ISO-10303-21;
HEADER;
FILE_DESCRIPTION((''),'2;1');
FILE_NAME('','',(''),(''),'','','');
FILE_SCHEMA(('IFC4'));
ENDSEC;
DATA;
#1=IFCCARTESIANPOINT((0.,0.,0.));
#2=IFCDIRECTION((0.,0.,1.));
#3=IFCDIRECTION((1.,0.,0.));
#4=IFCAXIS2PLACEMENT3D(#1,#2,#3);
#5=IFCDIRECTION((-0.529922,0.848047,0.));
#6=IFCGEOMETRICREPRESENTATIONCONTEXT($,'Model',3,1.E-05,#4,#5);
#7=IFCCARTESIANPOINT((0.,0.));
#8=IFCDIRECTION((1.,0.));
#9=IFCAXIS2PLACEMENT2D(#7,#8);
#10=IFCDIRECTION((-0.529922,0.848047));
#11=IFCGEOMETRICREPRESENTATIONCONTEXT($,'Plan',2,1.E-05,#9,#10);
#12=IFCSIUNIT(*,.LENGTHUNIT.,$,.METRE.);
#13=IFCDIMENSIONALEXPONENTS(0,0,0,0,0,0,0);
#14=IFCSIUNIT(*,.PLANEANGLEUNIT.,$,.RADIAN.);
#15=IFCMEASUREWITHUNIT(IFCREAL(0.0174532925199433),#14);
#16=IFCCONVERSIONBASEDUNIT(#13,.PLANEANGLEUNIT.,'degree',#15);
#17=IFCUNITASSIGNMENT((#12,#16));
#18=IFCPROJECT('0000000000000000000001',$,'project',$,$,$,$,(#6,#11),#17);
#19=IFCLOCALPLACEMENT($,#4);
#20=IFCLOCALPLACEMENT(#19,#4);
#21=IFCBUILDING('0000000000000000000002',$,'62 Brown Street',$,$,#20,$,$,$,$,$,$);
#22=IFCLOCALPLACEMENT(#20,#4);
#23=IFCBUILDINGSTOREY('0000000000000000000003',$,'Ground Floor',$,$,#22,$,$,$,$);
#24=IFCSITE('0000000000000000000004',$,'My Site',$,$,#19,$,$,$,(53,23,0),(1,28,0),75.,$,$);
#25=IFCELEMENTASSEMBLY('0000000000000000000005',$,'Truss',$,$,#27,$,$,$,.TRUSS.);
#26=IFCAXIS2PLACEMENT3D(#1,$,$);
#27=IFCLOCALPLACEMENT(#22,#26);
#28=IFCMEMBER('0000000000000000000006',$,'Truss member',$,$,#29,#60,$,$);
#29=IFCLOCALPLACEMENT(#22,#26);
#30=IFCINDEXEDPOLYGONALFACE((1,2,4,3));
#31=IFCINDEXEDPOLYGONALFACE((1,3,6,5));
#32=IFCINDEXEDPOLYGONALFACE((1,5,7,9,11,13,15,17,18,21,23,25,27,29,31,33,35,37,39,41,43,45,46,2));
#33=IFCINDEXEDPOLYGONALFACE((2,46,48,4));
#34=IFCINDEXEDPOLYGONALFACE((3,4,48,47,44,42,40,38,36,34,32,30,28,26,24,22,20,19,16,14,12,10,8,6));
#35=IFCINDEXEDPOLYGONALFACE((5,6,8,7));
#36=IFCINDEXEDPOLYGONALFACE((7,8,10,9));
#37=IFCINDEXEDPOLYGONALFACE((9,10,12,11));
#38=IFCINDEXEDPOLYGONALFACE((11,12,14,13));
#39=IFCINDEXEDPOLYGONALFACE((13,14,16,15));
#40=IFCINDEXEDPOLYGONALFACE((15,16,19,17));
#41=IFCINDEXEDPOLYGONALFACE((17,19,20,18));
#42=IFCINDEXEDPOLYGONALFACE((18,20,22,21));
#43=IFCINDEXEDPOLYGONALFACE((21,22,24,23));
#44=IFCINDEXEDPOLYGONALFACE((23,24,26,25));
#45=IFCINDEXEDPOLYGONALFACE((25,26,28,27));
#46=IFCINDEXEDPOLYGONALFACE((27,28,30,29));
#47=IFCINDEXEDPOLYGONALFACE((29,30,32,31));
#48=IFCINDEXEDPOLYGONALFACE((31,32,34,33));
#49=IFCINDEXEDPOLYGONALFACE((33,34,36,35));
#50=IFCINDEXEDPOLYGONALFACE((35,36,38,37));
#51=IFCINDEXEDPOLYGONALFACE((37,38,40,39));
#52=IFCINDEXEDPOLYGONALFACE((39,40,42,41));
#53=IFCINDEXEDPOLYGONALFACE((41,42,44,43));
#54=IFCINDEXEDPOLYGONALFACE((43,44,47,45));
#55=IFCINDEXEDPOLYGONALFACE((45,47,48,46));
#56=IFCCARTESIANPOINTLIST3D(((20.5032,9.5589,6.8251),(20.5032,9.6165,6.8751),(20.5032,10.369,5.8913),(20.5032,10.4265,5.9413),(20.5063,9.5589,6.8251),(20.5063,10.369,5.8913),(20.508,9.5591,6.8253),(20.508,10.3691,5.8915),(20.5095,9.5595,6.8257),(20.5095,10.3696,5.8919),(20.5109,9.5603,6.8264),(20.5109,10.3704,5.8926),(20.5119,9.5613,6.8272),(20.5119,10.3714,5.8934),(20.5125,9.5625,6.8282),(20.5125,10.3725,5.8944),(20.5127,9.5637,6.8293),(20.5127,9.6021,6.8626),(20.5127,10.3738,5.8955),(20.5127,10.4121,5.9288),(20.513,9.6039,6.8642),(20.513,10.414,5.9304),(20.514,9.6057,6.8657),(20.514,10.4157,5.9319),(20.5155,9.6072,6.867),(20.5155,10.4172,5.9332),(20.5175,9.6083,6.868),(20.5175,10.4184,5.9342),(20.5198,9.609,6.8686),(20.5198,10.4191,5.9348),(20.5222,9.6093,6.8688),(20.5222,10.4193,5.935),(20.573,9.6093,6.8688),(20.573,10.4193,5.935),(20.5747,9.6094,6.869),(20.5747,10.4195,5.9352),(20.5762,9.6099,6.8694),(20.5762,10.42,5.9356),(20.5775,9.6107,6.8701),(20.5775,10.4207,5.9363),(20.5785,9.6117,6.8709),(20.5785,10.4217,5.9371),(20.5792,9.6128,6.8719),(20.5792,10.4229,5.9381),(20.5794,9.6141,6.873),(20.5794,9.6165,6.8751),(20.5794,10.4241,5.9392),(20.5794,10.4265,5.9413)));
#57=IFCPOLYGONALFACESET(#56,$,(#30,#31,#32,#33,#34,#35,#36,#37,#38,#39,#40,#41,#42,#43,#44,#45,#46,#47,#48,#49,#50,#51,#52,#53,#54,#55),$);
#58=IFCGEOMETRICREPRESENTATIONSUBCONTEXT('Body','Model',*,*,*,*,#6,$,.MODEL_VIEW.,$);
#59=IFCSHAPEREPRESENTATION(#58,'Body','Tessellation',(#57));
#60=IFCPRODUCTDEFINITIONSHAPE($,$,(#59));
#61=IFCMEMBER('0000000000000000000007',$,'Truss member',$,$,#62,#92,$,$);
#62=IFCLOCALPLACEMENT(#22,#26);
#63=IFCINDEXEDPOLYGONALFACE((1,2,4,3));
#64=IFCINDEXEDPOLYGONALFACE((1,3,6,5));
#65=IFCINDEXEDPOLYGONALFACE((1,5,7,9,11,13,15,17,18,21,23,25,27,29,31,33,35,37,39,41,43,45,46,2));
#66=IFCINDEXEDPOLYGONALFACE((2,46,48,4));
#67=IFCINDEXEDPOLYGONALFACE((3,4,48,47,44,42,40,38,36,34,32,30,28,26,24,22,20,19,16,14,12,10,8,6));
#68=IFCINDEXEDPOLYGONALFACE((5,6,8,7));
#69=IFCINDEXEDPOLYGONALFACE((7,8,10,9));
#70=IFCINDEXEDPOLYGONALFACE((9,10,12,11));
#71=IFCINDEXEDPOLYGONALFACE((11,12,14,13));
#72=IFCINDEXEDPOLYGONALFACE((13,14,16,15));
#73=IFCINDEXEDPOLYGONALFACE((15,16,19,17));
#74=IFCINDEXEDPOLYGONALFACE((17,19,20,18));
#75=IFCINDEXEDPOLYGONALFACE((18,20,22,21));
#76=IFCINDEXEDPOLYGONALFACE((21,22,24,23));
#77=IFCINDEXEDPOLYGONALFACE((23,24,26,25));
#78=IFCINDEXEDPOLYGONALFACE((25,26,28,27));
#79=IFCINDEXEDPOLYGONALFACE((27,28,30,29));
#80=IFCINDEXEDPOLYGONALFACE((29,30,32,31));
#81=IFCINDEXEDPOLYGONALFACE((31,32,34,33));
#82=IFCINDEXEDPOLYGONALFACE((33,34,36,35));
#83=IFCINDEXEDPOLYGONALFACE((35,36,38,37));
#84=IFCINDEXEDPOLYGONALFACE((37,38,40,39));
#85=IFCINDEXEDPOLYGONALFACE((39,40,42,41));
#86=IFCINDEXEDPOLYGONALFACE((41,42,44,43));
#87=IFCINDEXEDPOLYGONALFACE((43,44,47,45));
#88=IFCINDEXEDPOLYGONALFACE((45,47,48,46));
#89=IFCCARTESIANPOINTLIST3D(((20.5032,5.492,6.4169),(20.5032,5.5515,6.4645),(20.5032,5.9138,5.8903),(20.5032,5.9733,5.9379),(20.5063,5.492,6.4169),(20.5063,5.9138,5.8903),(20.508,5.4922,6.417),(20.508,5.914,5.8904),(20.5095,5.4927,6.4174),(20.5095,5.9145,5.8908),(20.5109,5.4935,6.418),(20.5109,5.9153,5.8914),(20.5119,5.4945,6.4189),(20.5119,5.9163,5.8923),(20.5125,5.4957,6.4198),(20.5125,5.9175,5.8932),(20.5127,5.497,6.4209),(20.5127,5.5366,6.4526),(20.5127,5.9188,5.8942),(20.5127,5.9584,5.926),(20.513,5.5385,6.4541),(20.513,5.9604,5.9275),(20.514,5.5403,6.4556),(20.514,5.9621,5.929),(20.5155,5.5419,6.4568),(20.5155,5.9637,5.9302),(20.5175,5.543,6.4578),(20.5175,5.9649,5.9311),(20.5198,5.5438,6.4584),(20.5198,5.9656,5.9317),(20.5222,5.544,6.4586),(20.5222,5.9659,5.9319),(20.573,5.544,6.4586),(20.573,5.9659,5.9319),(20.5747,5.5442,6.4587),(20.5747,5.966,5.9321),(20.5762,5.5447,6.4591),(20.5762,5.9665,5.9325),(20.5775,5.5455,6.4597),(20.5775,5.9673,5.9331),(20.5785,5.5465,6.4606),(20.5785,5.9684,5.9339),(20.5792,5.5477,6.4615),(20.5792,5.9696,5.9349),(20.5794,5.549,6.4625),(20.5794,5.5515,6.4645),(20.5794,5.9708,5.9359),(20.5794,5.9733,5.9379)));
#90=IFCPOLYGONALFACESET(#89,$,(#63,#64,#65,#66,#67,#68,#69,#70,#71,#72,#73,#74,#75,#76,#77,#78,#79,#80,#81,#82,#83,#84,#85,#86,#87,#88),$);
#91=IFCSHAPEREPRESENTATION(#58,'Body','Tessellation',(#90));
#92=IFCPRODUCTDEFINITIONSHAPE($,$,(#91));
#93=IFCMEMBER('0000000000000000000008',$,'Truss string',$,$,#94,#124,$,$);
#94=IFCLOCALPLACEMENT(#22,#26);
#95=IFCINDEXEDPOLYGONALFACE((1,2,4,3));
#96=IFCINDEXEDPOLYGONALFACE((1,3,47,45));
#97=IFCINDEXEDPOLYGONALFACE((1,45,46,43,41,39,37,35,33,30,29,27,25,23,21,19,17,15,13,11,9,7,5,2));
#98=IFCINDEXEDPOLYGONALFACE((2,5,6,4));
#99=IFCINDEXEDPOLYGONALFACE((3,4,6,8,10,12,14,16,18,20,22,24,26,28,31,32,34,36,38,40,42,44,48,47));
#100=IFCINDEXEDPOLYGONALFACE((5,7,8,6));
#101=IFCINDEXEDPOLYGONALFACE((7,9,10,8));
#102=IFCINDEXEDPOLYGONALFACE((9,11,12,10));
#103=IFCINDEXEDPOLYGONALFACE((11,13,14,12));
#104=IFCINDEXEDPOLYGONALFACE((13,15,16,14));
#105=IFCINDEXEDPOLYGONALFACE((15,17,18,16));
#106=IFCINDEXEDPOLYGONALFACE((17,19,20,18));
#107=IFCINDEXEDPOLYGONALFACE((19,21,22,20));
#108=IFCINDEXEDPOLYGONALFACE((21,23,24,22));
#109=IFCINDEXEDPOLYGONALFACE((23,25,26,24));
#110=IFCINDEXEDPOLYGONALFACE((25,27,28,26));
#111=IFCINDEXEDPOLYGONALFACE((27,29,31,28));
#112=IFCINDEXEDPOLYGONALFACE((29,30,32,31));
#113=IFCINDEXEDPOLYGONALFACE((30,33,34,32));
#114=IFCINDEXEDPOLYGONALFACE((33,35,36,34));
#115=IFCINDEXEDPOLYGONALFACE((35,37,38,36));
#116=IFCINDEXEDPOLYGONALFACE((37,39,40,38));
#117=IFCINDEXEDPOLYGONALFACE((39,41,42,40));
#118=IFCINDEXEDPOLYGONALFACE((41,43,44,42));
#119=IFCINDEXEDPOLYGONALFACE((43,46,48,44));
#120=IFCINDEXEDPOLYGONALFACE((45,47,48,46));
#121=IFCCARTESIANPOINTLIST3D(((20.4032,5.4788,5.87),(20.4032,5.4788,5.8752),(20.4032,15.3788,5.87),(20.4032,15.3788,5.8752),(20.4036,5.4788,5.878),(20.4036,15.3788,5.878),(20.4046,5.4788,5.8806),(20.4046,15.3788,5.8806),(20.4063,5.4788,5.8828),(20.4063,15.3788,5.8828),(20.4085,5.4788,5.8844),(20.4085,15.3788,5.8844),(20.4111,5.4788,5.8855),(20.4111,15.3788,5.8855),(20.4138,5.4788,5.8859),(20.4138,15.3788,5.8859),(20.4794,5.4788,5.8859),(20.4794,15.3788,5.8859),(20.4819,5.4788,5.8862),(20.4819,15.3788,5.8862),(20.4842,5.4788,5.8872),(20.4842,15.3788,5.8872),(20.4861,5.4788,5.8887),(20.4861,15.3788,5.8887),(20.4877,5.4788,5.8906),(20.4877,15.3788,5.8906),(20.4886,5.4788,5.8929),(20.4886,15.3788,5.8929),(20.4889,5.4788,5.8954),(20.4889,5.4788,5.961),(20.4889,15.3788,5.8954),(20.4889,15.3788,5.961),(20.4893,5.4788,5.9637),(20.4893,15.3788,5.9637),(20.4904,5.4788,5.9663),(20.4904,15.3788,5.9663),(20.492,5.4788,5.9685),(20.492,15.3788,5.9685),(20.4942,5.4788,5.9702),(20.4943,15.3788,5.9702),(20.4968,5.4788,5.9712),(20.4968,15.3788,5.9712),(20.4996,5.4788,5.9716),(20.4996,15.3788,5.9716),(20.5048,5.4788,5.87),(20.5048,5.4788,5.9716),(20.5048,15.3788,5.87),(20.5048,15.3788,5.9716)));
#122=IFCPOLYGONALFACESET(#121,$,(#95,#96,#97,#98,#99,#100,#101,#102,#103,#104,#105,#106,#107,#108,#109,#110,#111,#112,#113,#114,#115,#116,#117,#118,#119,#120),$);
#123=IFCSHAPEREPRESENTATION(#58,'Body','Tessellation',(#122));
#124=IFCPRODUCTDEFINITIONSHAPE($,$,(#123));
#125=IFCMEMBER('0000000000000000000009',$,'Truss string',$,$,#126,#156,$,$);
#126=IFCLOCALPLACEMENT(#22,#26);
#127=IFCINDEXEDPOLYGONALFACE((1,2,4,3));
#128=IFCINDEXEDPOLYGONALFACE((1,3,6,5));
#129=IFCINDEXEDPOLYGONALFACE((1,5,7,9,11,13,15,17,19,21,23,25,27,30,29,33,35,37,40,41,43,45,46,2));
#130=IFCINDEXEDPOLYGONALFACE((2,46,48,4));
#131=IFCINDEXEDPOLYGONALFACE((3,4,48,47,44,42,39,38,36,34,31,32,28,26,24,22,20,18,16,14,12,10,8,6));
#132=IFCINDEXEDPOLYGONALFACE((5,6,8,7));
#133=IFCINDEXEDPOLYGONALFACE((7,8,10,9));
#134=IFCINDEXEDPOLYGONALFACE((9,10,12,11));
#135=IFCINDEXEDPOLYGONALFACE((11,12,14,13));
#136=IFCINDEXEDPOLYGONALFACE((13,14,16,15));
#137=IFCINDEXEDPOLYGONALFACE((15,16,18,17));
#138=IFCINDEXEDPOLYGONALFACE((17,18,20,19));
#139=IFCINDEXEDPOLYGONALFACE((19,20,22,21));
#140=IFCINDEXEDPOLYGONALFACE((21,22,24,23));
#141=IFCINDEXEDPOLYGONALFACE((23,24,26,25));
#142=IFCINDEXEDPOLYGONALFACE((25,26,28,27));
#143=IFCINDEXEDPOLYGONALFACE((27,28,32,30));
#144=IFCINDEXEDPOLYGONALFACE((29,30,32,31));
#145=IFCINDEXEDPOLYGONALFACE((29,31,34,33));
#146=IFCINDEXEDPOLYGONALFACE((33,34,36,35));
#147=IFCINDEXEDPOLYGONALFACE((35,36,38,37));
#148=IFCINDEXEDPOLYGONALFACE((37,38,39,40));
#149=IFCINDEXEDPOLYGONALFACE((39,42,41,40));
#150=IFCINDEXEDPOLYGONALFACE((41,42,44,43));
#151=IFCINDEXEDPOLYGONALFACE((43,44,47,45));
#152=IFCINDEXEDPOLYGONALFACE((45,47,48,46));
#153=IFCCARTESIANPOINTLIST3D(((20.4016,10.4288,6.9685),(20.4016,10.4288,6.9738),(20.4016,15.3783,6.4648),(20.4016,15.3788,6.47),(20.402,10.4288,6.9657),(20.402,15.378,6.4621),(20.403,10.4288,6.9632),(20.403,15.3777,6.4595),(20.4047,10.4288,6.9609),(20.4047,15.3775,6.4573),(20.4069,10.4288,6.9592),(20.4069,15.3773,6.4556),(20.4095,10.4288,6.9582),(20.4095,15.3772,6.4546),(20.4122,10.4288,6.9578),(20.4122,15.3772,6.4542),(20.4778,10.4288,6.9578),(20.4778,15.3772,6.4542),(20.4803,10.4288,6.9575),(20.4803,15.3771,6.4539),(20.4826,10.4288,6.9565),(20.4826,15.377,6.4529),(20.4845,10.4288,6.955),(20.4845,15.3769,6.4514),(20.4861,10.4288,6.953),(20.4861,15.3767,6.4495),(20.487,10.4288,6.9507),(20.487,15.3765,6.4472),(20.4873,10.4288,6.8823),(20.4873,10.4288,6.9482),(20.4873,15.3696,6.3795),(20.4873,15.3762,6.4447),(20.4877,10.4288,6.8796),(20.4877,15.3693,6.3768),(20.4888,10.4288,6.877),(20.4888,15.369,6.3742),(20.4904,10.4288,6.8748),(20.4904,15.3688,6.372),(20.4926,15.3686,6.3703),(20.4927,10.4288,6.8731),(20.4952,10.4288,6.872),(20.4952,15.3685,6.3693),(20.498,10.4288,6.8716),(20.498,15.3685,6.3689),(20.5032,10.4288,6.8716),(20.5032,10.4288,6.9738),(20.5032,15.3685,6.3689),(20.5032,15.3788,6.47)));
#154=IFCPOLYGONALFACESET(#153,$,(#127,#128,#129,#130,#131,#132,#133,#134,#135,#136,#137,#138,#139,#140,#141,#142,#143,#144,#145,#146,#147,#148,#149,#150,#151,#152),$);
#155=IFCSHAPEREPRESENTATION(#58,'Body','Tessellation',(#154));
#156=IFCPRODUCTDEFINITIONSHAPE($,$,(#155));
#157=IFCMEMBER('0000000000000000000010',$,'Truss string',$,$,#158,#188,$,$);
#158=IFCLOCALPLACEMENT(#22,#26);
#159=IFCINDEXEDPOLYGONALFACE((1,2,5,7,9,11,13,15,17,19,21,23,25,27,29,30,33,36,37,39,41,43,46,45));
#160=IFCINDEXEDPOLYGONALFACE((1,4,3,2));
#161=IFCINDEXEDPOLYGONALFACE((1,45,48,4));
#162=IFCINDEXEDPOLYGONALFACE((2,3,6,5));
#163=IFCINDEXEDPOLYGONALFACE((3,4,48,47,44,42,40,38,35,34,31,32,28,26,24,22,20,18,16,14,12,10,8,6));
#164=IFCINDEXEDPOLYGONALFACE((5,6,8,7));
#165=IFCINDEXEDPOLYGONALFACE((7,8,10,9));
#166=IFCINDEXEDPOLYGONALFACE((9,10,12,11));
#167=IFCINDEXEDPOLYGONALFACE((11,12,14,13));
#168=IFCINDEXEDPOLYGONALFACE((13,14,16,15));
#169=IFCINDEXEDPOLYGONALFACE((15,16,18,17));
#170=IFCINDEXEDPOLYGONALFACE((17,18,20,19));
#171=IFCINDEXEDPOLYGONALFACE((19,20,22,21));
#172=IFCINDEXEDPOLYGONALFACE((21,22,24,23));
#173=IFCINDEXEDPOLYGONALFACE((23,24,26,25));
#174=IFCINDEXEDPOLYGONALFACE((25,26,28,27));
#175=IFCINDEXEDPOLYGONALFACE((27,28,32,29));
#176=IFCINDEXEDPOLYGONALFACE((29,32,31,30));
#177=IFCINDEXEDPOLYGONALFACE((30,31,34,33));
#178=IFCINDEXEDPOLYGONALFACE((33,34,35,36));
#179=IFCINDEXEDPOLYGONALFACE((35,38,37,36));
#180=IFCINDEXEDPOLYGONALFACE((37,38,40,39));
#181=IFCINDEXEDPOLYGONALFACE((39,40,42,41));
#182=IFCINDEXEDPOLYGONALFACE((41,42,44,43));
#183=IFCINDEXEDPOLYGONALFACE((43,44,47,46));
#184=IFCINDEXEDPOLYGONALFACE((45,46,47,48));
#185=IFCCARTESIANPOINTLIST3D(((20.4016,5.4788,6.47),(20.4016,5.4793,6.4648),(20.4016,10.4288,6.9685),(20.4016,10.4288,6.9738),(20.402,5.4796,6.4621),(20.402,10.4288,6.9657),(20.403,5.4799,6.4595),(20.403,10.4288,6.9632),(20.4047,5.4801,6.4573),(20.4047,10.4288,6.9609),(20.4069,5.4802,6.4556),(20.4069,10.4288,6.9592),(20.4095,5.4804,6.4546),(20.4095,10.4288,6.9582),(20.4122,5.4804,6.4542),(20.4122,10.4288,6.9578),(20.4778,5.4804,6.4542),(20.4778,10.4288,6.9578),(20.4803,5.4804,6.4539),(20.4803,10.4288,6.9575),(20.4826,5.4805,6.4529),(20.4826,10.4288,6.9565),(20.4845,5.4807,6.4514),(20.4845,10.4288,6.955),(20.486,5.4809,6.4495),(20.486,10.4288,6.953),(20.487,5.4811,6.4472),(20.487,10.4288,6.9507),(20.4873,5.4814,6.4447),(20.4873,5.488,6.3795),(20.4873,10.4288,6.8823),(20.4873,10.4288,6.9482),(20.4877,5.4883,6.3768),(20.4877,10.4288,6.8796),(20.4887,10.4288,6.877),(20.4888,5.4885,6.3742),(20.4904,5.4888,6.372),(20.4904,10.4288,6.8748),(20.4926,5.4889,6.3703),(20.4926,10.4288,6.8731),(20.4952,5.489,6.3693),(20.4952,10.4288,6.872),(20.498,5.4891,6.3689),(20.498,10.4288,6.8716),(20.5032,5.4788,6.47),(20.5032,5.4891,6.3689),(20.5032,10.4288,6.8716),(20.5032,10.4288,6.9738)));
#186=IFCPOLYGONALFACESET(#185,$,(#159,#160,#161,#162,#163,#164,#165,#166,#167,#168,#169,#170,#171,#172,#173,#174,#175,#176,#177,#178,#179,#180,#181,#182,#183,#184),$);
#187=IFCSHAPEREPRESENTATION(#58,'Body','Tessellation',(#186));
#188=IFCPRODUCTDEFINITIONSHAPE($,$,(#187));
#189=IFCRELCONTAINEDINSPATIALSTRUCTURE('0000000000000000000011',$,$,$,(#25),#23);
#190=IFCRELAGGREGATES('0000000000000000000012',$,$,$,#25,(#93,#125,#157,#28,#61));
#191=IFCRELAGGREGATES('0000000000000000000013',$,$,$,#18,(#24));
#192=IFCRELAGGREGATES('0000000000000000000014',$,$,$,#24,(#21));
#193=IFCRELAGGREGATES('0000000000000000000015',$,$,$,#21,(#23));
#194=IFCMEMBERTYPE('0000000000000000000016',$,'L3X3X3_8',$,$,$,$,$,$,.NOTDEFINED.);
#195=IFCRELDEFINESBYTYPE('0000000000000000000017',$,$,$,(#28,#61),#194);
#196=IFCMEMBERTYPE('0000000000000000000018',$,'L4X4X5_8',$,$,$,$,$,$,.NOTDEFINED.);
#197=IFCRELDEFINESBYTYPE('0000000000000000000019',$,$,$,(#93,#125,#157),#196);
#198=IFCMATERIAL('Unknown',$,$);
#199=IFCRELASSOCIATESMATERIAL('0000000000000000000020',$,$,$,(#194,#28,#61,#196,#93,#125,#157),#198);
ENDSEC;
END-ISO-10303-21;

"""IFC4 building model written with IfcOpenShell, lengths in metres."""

from ifc_helpers import new_model, entity, si_unit, converted_unit, direction, frame, origin_with_axes, origin_2d_with_axis, place, context, subcontext, project, spatial, l_section, extrude, clip, halfspace, material, material_profile, profile_set, profile_usage, type_object, element, aggregate, save


model = new_model("IFC4")

# Units and contexts
model_context = context("Model", 3, precision=1e-05, world=origin_with_axes(), true_north=direction((-0.529922, 0.848047, 0.0)))
plan_context = context("Plan", 2, precision=1e-05, world=origin_2d_with_axis(), true_north=direction((-0.529922, 0.848047)))
body_context = subcontext(model_context, "Body", "Model", "MODEL_VIEW")
ifc_project = project(units=[si_unit("LENGTHUNIT", "METRE"), converted_unit("PLANEANGLEUNIT", "degree", entity("IfcReal", 0.0174532925199433), si_unit("PLANEANGLEUNIT", "RADIAN"), dimensions=[0, 0, 0, 0, 0, 0, 0])], contexts=[model_context, plan_context])

# Site, building, storey
site_placement = place(None, origin_with_axes())
site = spatial("IfcSite", under=ifc_project, at=site_placement, Name="My Site", RefLatitude=(53, 23, 0), RefLongitude=(1, 28, 0), RefElevation=75.0)
building_placement = place(site_placement, origin_with_axes())
building = spatial("IfcBuilding", under=site, at=building_placement, Name="62 Brown Street")
storey_placement = place(building_placement, origin_with_axes())
storey = spatial("IfcBuildingStorey", under=building, at=storey_placement, Name="Ground Floor")

# Element assembly, members
assembly_placement = place(storey_placement, frame((20.5032, 10.4288, 6.9738), z_axis=(0.0, 0.0, 1.0), x_axis=(1.0, 0.0, 0.0)))
assembly = element("IfcElementAssembly", 1, at=assembly_placement, inside=storey, Name="Truss", PredefinedType="TRUSS")
ifc_material_1 = material(Name="Unknown")
ifc_material_profile_1 = material_profile(ifc_material_1, l_section(Depth=0.0762, Width=0.0762, Thickness=0.0095, FilletRadius=0.0095, EdgeRadius=0.0064))
ifc_profile_set_1 = profile_set([ifc_material_profile_1])
member_type_1 = type_object("IfcMemberType", Name="L3X3X3_8", PredefinedType="NOTDEFINED", material=ifc_profile_set_1)
ifc_profile_usage_1 = profile_usage(ifc_profile_set_1, cardinal=5)
member_1_placement = place(assembly_placement, frame((0.0381, -0.8411, -0.1236), z_axis=(-0.000001, 0.655276, -0.755389), x_axis=(1.0, 0.000001, 0.0)))
member_1 = element("IfcMember", 2, at=member_1_placement, type_object=member_type_1, material=ifc_profile_usage_1, Name="Truss member", context=body_context, shape_type="SweptSolid", body=[
    extrude(l_section(Depth=0.0762, Width=0.0762, Thickness=0.0095, FilletRadius=0.0095, EdgeRadius=0.0064), origin_with_axes(), (0.0, 0.0, 1.0), 1.2362),
])
ifc_profile_usage_2 = profile_usage(ifc_profile_set_1, cardinal=5)
member_2_placement = place(assembly_placement, frame((0.0381, -4.907, -0.5331), z_axis=(-0.000001, 0.625169, -0.780489), x_axis=(1.0, 0.000001, 0.0)))
member_2 = element("IfcMember", 3, at=member_2_placement, type_object=member_type_1, material=ifc_profile_usage_2, Name="Truss member", context=body_context, shape_type="SweptSolid", body=[
    extrude(l_section(Depth=0.0762, Width=0.0762, Thickness=0.0095, FilletRadius=0.0095, EdgeRadius=0.0064), origin_with_axes(), (0.0, 0.0, 1.0), 0.6747),
])

# Members
ifc_material_profile_2 = material_profile(ifc_material_1, l_section(Depth=0.1016, Width=0.1016, Thickness=0.0159, FilletRadius=0.0095, EdgeRadius=0.0106))
ifc_profile_set_2 = profile_set([ifc_material_profile_2])
ifc_profile_usage_3 = profile_usage(ifc_profile_set_2, cardinal=5)
member_type_2 = type_object("IfcMemberType", Name="L4X4X5_8", PredefinedType="NOTDEFINED", material=ifc_profile_set_2)
member_3_placement = place(assembly_placement, frame((-0.0492, -4.95, -1.053), z_axis=(0.0, 1.0, 0.0), x_axis=(-1.0, 0.0, 0.0)))
member_3 = element("IfcMember", 4, at=member_3_placement, type_object=member_type_2, material=ifc_profile_usage_3, Name="Truss string", context=body_context, shape_type="SweptSolid", body=[
    extrude(l_section(Depth=0.1016, Width=0.1016, Thickness=0.0159, FilletRadius=0.0095, EdgeRadius=0.0106), origin_with_axes(), (0.0, 0.0, 1.0), 9.9),
])
ifc_profile_usage_4 = profile_usage(ifc_profile_set_2, cardinal=5)
member_4_placement = place(assembly_placement, frame((-0.0508, 4.9449, -0.5543), z_axis=(0.000001, -0.994861, 0.101247), x_axis=(-1.0, -0.000001, 0.0)))
member_4 = element("IfcMember", 5, at=member_4_placement, type_object=member_type_2, material=ifc_profile_usage_4, Name="Truss string", context=body_context, shape_type="Clipping", body=[
    clip(extrude(l_section(Depth=0.1016, Width=0.1016, Thickness=0.0159, FilletRadius=0.0095, EdgeRadius=0.0106), origin_with_axes(), (0.0, 0.0, 1.0), 5.3242), halfspace(frame((16.4524, -0.0508, 4.9756), z_axis=(0.0, 0.101247, 0.994861), x_axis=(1.0, -0.000001, 0.0)), False)),
])
ifc_profile_usage_5 = profile_usage(ifc_profile_set_2, cardinal=5)
member_5_placement = place(assembly_placement, frame((-0.0508, 0.3519, -0.0152), z_axis=(0.000001, -0.994861, -0.101247), x_axis=(-1.0, -0.000001, 0.0)))
member_5 = element("IfcMember", 6, at=member_5_placement, type_object=member_type_2, material=ifc_profile_usage_5, Name="Truss string", context=body_context, shape_type="Clipping", body=[
    clip(extrude(l_section(Depth=0.1016, Width=0.1016, Thickness=0.0159, FilletRadius=0.0095, EdgeRadius=0.0106), origin_with_axes(), (0.0, 0.0, 1.0), 5.3242), halfspace(frame((16.4524, -0.0508, 0.3486), z_axis=(0.0, 0.101247, -0.994861), x_axis=(1.0, -0.000001, 0.0)), False)),
])
aggregate(assembly, [member_3, member_4, member_5, member_1, member_2])

save(model, "model.ifc")
